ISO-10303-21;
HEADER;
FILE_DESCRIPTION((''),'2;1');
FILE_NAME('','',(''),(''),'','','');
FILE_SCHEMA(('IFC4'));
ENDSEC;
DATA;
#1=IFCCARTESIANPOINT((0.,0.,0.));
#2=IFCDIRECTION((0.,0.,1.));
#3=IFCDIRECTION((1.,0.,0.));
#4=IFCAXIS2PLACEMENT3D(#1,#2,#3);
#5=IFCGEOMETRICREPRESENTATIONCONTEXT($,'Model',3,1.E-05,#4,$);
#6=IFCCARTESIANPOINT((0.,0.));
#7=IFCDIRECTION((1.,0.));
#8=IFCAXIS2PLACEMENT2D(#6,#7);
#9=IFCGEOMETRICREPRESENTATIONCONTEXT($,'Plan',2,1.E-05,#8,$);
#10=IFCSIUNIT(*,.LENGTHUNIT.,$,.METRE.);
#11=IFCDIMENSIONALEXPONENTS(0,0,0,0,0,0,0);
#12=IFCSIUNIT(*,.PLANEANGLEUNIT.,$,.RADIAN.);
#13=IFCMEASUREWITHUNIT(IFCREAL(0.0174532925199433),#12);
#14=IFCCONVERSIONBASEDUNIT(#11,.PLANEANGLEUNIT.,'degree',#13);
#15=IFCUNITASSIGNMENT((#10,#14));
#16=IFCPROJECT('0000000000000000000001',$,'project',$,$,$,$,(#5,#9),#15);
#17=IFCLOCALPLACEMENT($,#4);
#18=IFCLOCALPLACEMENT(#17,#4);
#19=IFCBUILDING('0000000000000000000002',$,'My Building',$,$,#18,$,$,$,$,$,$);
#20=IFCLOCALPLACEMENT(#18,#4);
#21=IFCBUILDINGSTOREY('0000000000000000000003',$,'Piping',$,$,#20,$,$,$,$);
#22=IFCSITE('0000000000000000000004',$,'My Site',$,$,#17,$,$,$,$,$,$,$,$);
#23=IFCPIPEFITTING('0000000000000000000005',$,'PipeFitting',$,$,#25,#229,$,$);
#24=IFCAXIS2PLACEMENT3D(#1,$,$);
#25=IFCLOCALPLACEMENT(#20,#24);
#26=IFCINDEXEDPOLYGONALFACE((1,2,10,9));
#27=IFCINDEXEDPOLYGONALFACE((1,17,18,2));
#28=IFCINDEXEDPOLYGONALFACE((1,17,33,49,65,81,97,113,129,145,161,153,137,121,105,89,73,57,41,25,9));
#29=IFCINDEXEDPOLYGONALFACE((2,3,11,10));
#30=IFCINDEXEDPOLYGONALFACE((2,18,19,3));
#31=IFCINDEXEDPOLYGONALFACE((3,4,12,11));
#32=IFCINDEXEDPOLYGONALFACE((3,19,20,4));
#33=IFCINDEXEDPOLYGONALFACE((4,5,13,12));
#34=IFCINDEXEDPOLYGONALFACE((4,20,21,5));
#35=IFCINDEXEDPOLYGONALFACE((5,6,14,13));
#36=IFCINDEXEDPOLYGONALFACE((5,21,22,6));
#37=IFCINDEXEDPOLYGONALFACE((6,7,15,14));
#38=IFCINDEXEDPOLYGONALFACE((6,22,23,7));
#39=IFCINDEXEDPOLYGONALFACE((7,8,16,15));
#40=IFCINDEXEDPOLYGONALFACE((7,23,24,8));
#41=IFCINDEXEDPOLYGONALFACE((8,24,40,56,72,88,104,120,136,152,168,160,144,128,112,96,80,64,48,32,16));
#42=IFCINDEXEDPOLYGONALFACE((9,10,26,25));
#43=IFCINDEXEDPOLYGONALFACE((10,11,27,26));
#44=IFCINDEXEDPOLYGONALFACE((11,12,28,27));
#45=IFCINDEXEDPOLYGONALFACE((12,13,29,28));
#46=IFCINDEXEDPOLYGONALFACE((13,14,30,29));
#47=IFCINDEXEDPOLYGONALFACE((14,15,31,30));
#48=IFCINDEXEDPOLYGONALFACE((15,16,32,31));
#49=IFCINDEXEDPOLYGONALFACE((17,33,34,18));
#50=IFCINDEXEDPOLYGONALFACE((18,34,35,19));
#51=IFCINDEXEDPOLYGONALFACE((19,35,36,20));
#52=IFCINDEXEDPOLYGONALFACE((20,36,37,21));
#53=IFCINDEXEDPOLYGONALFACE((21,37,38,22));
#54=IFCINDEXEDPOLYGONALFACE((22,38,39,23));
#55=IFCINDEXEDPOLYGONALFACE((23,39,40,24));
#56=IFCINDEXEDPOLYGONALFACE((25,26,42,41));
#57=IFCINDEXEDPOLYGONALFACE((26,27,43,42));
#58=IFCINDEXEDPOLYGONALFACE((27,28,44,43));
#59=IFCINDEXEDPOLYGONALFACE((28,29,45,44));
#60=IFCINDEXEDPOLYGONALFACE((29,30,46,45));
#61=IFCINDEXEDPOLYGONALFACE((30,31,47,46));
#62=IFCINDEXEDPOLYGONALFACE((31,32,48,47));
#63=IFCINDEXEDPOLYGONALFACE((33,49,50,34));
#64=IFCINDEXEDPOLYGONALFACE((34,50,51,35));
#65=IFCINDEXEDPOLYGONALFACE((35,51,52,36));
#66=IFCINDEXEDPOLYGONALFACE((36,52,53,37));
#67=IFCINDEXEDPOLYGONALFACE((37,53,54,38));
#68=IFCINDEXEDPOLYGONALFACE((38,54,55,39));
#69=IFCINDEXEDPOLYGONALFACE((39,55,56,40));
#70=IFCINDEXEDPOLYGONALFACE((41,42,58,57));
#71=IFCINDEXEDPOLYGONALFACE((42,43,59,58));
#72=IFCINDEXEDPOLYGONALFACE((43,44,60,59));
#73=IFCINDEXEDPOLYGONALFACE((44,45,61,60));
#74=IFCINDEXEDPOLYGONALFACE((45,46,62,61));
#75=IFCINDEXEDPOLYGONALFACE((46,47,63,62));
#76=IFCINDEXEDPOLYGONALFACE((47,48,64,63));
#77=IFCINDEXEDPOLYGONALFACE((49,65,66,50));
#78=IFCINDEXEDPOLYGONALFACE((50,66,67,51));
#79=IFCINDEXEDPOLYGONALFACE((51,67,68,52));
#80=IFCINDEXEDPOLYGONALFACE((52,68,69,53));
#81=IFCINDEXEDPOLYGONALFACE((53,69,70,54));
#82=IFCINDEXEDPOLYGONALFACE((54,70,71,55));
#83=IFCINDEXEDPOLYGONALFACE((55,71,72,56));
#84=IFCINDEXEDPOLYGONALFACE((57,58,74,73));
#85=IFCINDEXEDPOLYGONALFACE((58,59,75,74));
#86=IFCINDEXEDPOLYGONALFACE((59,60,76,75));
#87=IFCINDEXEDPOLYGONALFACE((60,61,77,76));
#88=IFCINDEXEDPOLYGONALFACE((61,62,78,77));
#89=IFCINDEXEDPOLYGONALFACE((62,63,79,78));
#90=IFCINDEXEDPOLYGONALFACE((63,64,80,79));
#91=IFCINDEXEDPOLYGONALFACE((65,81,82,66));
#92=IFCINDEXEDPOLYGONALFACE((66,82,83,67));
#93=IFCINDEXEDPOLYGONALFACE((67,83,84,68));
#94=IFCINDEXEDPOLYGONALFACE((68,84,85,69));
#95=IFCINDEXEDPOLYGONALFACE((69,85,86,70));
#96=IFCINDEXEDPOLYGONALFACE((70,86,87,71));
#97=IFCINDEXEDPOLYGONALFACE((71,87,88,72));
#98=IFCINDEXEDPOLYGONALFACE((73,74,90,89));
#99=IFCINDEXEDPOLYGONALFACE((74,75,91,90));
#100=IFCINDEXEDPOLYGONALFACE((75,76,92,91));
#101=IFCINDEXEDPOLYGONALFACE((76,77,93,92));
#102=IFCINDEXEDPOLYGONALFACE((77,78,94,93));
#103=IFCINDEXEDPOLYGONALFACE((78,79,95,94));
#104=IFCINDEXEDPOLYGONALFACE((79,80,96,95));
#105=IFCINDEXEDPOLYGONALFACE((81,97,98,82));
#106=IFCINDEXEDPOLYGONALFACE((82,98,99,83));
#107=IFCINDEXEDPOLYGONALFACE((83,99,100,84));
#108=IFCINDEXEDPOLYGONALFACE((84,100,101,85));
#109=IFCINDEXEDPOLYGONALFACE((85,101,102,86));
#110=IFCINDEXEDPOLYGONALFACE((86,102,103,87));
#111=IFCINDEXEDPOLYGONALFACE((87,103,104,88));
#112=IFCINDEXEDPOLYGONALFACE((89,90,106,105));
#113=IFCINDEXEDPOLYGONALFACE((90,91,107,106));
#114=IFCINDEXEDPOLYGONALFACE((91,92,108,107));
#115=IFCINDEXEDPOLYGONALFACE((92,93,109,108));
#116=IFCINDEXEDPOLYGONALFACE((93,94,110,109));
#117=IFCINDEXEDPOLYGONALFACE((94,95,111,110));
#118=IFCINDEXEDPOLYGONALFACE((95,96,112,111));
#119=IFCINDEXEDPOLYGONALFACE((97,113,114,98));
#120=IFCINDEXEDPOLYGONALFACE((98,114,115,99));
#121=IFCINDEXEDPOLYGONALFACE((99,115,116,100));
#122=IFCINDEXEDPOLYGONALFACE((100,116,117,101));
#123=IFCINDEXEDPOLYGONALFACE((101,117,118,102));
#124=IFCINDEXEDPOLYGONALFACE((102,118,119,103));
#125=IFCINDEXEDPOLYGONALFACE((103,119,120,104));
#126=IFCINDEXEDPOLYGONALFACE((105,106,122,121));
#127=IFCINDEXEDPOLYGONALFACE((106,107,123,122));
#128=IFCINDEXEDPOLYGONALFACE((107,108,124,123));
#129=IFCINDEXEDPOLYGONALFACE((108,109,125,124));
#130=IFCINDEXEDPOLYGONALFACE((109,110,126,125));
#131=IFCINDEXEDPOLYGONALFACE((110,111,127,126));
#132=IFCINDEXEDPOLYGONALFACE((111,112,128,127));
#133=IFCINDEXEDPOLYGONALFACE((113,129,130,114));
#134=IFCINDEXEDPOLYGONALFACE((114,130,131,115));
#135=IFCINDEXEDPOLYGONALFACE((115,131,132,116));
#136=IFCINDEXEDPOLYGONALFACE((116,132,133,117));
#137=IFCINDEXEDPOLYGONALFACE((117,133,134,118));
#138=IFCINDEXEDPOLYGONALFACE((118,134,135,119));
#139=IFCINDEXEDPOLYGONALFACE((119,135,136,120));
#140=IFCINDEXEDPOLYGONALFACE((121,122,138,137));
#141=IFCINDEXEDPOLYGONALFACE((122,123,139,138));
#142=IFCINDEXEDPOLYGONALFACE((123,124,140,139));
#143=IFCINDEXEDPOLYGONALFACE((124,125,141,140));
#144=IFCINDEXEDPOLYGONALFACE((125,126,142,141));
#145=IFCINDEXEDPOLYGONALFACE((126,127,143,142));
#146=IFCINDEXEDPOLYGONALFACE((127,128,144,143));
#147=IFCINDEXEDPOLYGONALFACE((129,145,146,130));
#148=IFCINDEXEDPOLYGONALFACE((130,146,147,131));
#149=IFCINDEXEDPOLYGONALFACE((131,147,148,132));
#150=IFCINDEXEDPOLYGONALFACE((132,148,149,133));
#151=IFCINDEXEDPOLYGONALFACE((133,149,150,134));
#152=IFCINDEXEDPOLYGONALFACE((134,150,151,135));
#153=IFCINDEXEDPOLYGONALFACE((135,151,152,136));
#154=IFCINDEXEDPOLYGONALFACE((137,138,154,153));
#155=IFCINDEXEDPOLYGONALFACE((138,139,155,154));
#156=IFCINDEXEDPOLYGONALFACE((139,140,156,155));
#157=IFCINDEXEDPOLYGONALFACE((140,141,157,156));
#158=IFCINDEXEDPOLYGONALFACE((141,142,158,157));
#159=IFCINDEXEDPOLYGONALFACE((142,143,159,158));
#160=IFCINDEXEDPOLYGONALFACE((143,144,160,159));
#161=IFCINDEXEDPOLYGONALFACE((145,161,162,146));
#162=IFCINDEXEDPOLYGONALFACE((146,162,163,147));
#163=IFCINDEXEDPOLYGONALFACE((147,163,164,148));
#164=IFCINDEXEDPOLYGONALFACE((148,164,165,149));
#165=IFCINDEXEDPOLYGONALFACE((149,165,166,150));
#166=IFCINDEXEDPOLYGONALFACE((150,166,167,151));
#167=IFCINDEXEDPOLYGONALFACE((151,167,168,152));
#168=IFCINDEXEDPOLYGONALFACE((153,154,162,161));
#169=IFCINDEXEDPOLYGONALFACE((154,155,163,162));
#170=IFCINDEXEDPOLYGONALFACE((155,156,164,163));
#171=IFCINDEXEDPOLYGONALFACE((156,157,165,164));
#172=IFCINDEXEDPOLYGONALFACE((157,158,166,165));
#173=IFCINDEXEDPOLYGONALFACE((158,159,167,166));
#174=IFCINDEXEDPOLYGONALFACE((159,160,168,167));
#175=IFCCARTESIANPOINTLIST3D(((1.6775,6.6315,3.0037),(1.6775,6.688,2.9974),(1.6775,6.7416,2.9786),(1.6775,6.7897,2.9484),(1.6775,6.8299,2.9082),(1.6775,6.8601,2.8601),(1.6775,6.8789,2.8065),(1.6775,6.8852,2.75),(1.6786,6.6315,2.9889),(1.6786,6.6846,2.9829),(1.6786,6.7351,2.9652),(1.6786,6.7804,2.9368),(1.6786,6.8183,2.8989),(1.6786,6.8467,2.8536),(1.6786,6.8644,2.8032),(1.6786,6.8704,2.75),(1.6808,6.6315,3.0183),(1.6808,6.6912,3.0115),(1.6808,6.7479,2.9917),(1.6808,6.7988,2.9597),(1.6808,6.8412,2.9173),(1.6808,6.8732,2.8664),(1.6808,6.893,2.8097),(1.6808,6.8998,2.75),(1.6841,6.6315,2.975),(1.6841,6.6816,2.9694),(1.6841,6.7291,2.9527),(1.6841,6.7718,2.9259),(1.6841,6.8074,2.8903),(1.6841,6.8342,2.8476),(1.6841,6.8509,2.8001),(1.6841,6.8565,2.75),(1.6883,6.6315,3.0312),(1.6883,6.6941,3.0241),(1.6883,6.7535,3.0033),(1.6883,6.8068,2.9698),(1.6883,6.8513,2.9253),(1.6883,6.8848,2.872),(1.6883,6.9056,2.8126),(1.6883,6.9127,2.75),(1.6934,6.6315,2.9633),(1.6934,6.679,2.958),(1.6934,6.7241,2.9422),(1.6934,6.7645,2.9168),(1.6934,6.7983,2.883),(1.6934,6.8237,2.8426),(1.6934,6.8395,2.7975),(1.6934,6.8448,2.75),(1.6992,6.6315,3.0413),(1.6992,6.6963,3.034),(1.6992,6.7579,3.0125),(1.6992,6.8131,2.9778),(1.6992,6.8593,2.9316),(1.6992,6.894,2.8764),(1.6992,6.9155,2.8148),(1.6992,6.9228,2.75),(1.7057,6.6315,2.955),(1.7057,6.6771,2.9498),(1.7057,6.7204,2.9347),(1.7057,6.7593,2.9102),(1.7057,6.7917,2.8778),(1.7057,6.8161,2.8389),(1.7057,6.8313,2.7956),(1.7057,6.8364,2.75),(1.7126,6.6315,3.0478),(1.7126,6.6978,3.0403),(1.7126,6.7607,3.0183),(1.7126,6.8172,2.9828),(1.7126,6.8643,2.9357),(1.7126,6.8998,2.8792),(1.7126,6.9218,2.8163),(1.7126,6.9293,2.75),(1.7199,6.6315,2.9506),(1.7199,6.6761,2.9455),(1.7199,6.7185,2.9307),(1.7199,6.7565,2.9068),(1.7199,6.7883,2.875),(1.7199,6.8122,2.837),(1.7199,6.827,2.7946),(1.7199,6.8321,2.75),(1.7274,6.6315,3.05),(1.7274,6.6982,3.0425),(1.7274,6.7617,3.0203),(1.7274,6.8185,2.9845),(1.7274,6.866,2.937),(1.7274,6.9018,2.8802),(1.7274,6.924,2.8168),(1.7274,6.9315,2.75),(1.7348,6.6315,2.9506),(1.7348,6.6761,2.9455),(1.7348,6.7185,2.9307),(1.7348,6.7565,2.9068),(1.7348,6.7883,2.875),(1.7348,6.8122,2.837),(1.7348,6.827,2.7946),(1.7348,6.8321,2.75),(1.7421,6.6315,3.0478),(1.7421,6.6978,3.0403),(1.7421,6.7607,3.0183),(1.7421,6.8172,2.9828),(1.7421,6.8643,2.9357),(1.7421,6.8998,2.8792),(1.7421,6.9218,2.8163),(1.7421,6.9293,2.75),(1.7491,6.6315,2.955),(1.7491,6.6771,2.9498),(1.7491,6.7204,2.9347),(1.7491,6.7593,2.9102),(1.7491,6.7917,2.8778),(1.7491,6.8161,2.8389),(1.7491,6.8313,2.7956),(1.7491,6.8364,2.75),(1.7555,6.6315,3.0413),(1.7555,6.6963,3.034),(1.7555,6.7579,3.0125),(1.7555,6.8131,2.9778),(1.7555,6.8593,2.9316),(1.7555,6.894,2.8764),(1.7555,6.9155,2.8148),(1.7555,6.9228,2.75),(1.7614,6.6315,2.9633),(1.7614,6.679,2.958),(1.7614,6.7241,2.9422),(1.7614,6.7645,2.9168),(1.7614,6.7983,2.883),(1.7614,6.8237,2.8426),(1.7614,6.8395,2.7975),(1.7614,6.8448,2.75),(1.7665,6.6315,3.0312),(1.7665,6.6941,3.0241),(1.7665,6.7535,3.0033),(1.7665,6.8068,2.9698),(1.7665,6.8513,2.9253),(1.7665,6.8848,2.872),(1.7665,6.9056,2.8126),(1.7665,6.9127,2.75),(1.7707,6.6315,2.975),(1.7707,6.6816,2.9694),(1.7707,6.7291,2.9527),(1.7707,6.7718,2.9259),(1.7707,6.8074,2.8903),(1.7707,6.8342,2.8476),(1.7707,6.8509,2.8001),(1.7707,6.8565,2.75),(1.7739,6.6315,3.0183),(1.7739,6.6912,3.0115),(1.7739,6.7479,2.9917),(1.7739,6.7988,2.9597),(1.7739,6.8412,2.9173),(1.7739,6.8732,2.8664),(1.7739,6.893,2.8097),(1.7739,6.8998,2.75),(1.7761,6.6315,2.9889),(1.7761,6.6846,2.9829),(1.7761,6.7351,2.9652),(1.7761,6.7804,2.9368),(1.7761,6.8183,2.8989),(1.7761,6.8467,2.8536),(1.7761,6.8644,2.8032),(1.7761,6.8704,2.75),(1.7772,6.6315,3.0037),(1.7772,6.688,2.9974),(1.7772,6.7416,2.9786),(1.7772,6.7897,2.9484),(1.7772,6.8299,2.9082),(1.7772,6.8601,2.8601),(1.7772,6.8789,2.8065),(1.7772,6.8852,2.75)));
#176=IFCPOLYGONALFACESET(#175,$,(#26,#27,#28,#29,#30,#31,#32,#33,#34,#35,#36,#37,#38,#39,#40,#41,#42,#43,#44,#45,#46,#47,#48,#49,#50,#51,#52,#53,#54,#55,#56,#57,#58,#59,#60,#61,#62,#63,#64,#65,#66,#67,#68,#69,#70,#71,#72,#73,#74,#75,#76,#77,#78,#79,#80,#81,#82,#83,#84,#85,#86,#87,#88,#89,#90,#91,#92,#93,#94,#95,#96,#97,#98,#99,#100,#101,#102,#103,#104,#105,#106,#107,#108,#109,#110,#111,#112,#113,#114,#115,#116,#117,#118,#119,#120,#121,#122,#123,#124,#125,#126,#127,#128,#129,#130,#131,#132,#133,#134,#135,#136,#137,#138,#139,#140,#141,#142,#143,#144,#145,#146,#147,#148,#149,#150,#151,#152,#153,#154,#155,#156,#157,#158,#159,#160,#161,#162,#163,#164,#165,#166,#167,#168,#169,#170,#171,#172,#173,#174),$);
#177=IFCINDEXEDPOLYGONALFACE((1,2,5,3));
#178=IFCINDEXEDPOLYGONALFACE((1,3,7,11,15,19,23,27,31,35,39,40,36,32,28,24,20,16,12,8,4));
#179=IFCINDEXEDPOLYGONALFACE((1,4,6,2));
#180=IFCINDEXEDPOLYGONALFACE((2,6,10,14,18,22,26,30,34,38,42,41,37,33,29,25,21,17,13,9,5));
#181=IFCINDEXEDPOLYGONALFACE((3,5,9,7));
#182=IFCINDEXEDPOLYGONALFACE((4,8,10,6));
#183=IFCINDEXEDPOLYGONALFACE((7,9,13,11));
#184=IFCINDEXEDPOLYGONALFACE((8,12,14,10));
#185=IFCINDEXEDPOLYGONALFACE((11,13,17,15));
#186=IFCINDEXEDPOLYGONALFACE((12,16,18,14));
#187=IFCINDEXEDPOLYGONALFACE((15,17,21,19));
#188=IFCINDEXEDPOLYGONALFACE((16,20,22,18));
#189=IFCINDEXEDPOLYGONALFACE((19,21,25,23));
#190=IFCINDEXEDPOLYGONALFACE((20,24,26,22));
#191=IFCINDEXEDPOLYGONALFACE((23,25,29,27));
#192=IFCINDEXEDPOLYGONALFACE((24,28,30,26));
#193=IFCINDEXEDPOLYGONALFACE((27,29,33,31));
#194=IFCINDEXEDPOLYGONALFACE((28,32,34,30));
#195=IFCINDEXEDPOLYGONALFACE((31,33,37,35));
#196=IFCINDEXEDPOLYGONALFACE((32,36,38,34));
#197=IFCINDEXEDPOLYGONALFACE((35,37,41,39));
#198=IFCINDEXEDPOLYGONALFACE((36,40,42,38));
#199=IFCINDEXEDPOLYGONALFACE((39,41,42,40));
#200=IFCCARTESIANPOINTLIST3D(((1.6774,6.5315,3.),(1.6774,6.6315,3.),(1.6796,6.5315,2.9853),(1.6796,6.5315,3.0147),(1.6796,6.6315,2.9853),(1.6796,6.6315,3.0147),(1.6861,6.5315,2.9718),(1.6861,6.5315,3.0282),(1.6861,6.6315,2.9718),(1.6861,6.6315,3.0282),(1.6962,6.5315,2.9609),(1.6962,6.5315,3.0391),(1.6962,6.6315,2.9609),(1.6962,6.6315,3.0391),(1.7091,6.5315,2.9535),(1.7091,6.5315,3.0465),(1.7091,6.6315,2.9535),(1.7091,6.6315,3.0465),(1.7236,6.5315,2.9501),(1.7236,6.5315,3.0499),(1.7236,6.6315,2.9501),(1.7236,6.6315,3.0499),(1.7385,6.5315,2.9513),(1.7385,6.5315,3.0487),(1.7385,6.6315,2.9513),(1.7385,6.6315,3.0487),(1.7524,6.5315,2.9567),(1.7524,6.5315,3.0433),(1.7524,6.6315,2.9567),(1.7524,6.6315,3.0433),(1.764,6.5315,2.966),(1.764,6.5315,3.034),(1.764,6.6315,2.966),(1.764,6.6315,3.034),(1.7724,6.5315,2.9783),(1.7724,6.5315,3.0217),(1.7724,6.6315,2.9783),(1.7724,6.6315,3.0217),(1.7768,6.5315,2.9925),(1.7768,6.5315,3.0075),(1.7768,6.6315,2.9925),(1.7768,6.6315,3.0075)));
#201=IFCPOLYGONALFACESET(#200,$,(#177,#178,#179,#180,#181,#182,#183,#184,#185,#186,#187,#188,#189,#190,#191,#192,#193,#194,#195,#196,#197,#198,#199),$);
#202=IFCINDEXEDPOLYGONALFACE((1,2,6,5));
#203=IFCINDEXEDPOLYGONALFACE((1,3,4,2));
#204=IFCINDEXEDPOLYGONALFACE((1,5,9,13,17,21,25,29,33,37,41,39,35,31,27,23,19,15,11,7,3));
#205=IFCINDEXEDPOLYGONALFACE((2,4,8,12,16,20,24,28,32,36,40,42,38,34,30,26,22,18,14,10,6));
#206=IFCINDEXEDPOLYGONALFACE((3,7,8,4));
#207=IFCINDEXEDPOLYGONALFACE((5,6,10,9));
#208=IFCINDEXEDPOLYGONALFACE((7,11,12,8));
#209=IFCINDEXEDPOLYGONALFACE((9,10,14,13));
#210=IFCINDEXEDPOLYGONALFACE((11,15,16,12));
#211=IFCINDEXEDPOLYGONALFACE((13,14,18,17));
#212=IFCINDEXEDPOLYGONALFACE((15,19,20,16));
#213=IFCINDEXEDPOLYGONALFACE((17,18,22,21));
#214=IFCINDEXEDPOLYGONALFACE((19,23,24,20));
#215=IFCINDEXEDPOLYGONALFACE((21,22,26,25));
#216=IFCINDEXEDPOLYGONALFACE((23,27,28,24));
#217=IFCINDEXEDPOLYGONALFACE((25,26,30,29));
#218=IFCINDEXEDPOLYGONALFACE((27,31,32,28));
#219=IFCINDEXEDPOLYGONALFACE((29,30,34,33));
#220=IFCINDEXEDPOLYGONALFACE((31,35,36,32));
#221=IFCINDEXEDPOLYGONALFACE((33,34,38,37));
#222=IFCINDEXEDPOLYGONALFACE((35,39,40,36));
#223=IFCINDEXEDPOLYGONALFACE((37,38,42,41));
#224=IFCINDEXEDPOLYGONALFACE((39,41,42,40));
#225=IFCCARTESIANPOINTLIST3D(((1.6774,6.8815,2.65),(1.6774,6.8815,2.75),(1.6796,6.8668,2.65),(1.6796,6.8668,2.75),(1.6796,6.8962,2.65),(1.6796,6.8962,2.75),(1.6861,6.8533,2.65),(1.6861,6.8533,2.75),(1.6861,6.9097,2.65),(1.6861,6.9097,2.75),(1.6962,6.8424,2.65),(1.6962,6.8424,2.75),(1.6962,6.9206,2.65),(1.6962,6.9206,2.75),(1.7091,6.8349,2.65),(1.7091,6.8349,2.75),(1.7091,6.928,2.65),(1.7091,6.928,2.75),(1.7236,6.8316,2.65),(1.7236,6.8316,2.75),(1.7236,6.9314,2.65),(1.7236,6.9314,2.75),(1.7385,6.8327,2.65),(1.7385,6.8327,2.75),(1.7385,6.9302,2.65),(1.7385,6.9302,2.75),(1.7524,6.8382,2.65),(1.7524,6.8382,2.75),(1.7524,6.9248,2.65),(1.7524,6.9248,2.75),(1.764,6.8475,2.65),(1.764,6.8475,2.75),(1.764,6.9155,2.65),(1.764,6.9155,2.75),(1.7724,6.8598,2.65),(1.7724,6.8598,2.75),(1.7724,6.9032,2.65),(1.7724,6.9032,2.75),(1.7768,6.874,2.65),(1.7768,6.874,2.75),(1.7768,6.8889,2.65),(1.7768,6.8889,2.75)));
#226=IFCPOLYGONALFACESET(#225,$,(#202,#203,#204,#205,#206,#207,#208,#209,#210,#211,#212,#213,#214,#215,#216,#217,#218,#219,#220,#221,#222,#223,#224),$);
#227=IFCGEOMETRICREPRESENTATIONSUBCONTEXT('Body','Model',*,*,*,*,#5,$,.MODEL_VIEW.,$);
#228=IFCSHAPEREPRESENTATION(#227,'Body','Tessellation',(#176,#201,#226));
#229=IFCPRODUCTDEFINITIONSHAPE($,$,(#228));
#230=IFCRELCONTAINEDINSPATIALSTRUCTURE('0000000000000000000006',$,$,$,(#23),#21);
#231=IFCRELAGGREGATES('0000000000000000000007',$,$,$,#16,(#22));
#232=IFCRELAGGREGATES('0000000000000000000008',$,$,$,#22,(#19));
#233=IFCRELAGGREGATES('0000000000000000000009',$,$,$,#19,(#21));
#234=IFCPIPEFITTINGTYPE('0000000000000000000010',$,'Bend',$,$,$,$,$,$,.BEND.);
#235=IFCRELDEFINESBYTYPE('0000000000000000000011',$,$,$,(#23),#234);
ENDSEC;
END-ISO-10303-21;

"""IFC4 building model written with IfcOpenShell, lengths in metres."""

from ifc_helpers import new_model, entity, si_unit, converted_unit, frame, origin_with_axes, origin_2d_with_axis, place, context, subcontext, project, spatial, circle, extrude, source, transform, mapped, type_object, type_shapes, element, save


model = new_model("IFC4")

# Units and contexts
model_context = context("Model", 3, precision=1e-05, world=origin_with_axes())
plan_context = context("Plan", 2, precision=1e-05, world=origin_2d_with_axis())
body_context = subcontext(model_context, "Body", "Model", "MODEL_VIEW")
ifc_project = project(units=[si_unit("LENGTHUNIT", "METRE"), converted_unit("PLANEANGLEUNIT", "degree", entity("IfcReal", 0.0174532925199433), si_unit("PLANEANGLEUNIT", "RADIAN"), dimensions=[0, 0, 0, 0, 0, 0, 0])], contexts=[model_context, plan_context])

# Site, building, storey
site_placement = place(None, origin_with_axes())
site = spatial("IfcSite", under=ifc_project, at=site_placement, Name="My Site")
building_placement = place(site_placement, origin_with_axes())
building = spatial("IfcBuilding", under=site, at=building_placement, Name="My Building")
storey_placement = place(building_placement, origin_with_axes())
storey = spatial("IfcBuildingStorey", under=building, at=storey_placement, Name="Piping")

# Pipe fitting
pipe_fitting_type_1 = type_object("IfcPipeFittingType", Name="Bend", PredefinedType="BEND")
shared_shape = source(origin_with_axes(), body_context, "Body", "SolidModel", [
    entity("IfcSweptDiskSolid", entity("IfcIndexedPolyCurve", entity("IfcCartesianPointList3D", [[0.0, 0.0, -0.1], [0.0, 0.0732, -0.2768], [0.0, 0.25, -0.35]]), [entity("IfcArcIndex", [1, 2, 3])]), 0.05),
    extrude(circle(Radius=0.05), origin_with_axes(), (0.0, 0.0, -1.0), 0.1),
    extrude(circle(Radius=0.05), frame((0.0, 0.25, -0.35), z_axis=(0.0, 1.0, 0.0), x_axis=(1.0, 0.0, 0.0)), (0.0, 0.0, 1.0), 0.1),
])
type_shapes(pipe_fitting_type_1, [shared_shape])
for number, where, z_axis, x_axis, name in (
    (1, (1.7274, 6.5315, 3.0), (0.0, -1.0, 0.0), (-1.0, 0.0, 0.0), "PipeFitting"),
):
    element("IfcPipeFitting", number, at=place(storey_placement, frame(where, z_axis=z_axis, x_axis=x_axis)), inside=storey, type_object=pipe_fitting_type_1, Name=name, context=body_context, shape_type="MappedRepresentation", body=[
        mapped(shared_shape, transform((0.0, 0.0, 0.0), x_axis=(1.0, 0.0, 0.0), y_axis=(0.0, 1.0, 0.0), z_axis=(0.0, 0.0, 1.0), scale=1.0)),
    ])

save(model, "model.ifc")
